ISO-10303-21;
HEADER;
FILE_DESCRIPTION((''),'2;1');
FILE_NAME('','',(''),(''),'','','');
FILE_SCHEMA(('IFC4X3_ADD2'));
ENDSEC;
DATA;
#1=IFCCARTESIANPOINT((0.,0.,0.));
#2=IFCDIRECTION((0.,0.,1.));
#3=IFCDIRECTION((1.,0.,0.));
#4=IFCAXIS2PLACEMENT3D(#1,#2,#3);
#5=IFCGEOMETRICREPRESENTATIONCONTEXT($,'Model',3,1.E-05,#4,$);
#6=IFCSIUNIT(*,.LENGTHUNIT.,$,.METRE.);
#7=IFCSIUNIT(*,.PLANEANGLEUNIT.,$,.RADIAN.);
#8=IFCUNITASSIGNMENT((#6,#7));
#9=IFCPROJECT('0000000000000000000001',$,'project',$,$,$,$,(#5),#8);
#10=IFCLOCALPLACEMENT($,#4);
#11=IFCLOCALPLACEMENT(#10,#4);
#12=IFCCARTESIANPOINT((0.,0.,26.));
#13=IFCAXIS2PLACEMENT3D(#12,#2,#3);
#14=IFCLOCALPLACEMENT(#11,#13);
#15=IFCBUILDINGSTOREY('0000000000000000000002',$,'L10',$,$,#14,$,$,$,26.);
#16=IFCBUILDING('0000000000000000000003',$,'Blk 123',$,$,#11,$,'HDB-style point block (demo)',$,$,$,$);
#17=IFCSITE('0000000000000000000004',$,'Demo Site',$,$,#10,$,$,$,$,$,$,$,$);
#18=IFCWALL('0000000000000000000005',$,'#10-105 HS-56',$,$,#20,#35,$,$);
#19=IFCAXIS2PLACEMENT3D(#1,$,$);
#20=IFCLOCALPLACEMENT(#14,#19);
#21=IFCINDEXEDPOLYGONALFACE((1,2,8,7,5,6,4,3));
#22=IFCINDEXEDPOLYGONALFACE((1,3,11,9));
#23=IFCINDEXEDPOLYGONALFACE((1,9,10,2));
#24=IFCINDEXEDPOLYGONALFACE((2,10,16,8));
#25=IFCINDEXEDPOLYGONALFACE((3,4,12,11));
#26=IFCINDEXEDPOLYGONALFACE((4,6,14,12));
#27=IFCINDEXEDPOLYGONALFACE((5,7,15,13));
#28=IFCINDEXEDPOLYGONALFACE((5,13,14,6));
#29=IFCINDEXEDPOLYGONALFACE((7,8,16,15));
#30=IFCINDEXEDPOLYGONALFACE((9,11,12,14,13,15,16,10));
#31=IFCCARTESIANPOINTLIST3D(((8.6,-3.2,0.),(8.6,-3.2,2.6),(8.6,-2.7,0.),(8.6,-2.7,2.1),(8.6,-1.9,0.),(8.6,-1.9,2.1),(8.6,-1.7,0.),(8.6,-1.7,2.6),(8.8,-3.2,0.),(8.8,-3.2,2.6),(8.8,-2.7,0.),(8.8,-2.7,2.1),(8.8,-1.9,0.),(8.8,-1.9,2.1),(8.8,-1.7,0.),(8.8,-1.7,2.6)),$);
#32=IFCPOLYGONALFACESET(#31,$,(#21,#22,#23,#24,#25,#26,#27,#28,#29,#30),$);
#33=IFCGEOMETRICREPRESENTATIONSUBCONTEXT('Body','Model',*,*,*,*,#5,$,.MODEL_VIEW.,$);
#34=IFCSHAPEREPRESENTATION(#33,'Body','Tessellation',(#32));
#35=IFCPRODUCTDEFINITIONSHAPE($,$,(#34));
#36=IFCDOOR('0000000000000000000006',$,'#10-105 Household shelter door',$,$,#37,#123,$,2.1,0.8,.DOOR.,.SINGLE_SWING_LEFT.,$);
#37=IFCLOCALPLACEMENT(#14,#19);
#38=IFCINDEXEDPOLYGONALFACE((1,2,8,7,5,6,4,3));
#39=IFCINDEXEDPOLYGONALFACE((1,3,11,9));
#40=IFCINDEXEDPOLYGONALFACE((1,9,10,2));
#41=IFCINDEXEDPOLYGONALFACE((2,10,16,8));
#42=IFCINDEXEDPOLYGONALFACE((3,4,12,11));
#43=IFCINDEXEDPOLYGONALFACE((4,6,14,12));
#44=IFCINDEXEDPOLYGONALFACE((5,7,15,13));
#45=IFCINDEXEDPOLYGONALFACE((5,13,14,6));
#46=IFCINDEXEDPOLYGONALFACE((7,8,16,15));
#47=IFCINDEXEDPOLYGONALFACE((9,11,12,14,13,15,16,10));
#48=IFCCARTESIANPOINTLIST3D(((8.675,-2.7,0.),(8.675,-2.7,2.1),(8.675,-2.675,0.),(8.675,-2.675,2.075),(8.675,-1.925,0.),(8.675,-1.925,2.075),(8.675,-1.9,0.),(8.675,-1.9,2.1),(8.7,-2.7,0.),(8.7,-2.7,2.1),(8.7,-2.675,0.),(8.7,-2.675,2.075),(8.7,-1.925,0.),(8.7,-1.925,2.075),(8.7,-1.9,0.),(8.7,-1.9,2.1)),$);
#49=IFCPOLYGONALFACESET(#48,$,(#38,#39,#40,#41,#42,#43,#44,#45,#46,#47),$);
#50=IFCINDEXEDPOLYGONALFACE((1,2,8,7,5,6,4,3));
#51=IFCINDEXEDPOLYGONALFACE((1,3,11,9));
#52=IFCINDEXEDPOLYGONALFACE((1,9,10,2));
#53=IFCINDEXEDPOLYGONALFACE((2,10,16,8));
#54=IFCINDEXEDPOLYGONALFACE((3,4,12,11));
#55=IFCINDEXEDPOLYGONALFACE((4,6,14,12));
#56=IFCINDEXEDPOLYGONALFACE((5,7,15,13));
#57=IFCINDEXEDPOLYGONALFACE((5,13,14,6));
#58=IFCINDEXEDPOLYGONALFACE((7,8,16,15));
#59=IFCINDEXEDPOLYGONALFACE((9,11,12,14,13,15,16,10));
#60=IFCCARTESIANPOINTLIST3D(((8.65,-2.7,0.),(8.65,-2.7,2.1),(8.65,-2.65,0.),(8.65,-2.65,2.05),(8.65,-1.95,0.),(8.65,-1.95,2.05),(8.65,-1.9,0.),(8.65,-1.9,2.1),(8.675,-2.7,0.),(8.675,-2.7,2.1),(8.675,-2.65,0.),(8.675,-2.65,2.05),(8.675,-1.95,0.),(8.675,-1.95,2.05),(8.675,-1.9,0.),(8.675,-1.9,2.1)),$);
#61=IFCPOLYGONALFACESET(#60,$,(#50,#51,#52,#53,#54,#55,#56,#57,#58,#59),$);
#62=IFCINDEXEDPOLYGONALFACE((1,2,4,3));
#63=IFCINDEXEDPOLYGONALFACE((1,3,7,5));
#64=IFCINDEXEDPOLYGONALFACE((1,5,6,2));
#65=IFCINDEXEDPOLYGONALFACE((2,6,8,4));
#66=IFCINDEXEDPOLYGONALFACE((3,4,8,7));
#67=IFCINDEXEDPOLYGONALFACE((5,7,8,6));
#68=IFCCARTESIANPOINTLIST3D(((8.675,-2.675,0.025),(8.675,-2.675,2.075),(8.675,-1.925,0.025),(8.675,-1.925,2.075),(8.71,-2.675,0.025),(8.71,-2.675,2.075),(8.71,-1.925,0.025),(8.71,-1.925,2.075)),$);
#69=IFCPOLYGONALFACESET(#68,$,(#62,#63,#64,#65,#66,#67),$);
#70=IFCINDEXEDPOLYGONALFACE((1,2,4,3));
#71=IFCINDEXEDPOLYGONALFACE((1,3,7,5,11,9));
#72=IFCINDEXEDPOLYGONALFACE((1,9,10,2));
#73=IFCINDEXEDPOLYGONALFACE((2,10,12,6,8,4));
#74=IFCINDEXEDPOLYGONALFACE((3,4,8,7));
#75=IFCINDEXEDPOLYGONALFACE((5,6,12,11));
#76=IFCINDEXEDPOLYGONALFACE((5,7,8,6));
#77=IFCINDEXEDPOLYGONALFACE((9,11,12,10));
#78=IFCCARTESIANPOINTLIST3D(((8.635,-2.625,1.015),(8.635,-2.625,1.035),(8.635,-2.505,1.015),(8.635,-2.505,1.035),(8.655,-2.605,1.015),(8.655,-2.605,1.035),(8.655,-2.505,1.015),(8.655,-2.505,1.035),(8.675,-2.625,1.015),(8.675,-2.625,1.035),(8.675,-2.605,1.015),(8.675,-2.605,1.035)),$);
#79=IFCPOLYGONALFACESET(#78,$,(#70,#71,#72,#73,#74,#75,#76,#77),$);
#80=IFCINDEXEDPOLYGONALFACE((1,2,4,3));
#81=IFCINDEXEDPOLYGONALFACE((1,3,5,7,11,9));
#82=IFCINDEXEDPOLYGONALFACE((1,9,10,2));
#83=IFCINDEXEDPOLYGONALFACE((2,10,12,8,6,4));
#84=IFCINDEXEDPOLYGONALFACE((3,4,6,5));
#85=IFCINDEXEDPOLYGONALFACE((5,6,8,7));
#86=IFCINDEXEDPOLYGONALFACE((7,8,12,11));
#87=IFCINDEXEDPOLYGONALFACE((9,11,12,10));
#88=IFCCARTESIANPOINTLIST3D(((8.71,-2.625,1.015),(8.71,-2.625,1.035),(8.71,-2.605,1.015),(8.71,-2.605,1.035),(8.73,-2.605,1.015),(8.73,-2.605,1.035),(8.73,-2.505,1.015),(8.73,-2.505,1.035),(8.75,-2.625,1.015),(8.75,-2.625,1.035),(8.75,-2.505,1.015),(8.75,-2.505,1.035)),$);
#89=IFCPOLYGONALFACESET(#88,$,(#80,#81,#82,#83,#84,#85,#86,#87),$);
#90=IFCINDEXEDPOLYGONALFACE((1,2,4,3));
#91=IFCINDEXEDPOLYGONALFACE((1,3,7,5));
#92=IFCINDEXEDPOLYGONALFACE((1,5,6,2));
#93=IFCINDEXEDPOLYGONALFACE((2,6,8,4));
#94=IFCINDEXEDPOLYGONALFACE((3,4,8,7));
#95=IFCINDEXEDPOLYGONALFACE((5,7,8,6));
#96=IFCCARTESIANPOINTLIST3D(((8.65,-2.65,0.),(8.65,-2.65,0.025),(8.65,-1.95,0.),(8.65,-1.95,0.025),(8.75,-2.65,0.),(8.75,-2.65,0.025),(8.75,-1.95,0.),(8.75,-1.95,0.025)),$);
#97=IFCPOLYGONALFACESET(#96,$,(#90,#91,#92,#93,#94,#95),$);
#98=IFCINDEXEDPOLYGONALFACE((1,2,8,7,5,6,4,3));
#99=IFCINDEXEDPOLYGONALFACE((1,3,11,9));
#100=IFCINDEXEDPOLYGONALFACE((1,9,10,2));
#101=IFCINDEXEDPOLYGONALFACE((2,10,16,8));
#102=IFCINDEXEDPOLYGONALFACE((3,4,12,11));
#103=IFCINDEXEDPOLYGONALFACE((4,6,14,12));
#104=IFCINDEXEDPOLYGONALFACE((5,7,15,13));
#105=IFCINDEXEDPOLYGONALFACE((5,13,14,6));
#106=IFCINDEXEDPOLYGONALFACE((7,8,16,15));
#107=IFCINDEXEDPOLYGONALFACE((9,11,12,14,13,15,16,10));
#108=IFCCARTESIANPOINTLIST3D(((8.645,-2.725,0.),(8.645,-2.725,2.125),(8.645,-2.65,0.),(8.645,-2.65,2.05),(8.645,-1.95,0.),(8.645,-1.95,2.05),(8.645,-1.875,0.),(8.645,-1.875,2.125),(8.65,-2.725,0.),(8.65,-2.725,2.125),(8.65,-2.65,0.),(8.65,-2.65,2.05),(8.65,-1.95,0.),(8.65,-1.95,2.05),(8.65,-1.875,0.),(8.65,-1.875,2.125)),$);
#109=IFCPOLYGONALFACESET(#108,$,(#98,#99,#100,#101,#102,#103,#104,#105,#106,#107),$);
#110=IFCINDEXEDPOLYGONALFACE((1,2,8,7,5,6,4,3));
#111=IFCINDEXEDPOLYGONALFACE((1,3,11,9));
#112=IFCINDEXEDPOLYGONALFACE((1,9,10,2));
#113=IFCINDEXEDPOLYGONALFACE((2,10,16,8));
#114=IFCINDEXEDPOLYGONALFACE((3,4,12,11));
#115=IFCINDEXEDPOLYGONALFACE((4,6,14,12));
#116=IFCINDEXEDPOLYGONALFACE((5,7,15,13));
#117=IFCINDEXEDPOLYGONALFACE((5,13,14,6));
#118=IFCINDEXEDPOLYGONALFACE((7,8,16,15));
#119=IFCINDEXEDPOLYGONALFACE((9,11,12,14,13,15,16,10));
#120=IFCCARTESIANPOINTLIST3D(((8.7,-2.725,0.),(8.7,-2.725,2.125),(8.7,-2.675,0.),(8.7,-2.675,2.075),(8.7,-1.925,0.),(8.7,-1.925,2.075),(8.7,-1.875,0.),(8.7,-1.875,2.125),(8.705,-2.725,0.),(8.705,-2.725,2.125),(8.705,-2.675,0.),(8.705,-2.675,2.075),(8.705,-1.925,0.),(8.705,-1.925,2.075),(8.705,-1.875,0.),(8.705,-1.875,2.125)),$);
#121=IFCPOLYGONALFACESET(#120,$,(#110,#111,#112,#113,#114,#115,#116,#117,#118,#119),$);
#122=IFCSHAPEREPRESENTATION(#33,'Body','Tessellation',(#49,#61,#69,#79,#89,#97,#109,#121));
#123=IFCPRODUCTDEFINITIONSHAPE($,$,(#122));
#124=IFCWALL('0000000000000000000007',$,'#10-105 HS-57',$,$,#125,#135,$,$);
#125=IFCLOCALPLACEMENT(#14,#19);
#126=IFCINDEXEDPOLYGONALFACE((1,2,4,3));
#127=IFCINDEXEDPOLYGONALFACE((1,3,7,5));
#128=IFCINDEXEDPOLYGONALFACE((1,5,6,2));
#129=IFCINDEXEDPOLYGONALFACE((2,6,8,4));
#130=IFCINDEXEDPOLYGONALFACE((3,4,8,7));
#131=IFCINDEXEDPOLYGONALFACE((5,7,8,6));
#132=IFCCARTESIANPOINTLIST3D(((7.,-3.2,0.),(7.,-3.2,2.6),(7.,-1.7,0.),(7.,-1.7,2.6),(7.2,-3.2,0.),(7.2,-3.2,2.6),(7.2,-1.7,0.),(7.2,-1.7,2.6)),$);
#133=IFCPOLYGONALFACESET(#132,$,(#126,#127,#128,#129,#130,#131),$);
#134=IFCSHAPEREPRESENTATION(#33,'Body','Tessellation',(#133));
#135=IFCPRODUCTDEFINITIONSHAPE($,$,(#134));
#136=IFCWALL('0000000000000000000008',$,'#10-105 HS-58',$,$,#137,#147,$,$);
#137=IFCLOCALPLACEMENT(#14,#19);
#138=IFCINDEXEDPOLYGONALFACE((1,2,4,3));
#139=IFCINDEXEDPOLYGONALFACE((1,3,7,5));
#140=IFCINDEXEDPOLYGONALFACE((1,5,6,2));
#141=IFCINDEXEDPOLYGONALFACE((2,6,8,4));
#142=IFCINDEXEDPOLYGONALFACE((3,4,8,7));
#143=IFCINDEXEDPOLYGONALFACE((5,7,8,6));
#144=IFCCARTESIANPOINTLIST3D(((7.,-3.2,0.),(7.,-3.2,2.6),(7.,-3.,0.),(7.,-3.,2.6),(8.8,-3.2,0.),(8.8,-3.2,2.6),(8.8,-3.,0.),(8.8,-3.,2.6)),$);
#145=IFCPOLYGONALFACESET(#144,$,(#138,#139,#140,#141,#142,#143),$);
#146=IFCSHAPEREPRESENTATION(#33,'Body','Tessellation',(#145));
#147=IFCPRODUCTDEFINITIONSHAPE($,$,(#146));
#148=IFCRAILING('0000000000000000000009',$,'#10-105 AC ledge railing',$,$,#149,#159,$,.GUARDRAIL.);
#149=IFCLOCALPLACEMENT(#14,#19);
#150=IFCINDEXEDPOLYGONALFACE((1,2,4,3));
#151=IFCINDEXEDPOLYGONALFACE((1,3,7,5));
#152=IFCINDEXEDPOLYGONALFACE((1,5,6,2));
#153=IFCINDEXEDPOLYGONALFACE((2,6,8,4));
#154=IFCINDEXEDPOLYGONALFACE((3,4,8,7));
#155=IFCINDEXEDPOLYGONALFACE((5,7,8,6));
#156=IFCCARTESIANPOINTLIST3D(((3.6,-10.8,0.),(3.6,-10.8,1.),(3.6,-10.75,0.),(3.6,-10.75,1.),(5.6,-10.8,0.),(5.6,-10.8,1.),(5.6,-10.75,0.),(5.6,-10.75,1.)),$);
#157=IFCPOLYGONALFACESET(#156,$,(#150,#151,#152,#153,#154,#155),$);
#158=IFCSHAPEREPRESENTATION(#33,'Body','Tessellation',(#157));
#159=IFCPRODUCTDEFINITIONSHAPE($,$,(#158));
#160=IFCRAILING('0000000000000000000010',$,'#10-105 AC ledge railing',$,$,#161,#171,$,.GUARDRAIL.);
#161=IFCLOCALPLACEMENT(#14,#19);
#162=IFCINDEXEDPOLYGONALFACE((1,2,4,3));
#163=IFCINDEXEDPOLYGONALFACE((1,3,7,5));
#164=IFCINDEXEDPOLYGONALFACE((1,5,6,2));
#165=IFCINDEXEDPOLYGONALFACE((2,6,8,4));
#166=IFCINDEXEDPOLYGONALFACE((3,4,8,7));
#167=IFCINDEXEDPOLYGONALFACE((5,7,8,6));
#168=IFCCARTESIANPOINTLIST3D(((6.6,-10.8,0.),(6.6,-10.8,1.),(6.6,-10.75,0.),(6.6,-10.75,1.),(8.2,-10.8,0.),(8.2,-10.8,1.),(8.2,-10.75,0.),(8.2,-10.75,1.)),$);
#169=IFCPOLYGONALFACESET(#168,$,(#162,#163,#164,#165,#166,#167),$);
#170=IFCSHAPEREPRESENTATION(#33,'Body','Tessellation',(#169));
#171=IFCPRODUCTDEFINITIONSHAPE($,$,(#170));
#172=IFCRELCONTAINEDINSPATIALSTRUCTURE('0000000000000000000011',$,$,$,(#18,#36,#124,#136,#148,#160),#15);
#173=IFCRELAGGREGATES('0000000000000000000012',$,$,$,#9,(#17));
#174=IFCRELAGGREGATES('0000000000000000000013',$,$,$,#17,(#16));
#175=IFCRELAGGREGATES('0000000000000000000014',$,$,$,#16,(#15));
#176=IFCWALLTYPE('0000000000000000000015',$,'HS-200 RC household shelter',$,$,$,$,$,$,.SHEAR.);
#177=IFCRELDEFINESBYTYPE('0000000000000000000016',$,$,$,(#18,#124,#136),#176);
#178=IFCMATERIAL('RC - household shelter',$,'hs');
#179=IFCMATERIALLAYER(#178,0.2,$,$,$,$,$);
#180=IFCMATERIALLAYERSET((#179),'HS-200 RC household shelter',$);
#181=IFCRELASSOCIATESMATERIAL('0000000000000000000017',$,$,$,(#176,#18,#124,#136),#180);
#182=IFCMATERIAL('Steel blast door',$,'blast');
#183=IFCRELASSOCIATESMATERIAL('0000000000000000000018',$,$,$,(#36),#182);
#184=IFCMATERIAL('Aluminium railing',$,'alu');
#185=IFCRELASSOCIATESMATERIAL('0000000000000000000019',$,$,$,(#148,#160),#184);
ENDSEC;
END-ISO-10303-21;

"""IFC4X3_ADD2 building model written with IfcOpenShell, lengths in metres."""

from ifc_helpers import new_model, si_unit, frame, origin, origin_with_axes, place, context, subcontext, project, spatial, polyline, line, indexed_curve, outline, extrude, material, layer, layer_set, layer_usage, type_object, element, fill, save


model = new_model("IFC4X3_ADD2")

# Units and contexts
model_context = context("Model", 3, precision=1e-05, world=origin_with_axes())
body_context = subcontext(model_context, "Body", "Model", "MODEL_VIEW")
ifc_project = project(units=[si_unit("LENGTHUNIT", "METRE"), si_unit("PLANEANGLEUNIT", "RADIAN")], contexts=[model_context])

# Site, building, storey
site_placement = place(None, origin_with_axes())
site = spatial("IfcSite", under=ifc_project, at=site_placement, Name="Demo Site")
building_placement = place(site_placement, origin_with_axes())
building = spatial("IfcBuilding", under=site, at=building_placement, Name="Blk 123", LongName="HDB-style point block (demo)")
storey_placement = place(building_placement, frame((0.0, 0.0, 26.0), z_axis=(0.0, 0.0, 1.0), x_axis=(1.0, 0.0, 0.0)))
storey = spatial("IfcBuildingStorey", under=building, at=storey_placement, Name="L10", Elevation=26.0)

# Wall, opening, door
ifc_material_1 = material(Name="RC - household shelter", Category="hs")
ifc_layer_1 = layer(ifc_material_1, 0.2)
ifc_layer_set_1 = layer_set([ifc_layer_1], Name="HS-200 RC household shelter")
ifc_layer_usage_1 = layer_usage(ifc_layer_set_1, "AXIS2", "POSITIVE", -0.1)
wall_type_1 = type_object("IfcWallType", Name="HS-200 RC household shelter", PredefinedType="SHEAR", material=ifc_layer_set_1)
wall_1_placement = place(storey_placement, frame((8.7, -1.7, 0.0), z_axis=(0.0, 0.0, 1.0), x_axis=(0.0, -1.0, 0.0)))
wall_1 = element("IfcWall", 1, at=wall_1_placement, inside=storey, type_object=wall_type_1, material=ifc_layer_usage_1, Name="#10-105 HS-56", context=body_context, shape_type="SweptSolid", body=[
    extrude(outline(indexed_curve([(0.0, 0.0), (0.0, 0.2), (1.5, 0.2), (1.5, 0.0), (0.0, 0.0)], self_intersect=False)), frame((0.0, -0.1, 0.0), z_axis=(0.0, 0.0, 1.0), x_axis=(1.0, 0.0, 0.0)), (0.0, 0.0, 1.0), 2.6),
])
opening_1_placement = place(wall_1_placement, frame((0.2, -0.2, 0.0), z_axis=(0.0, 0.0, 1.0), x_axis=(1.0, 0.0, 0.0)))
opening_1 = element("IfcOpeningElement", 2, at=opening_1_placement, cuts=wall_1, context=body_context, shape_type="SweptSolid", body=[
    extrude(outline(indexed_curve([(0.0, 0.0), (0.0, 0.4), (0.8, 0.4), (0.8, 0.0), (0.0, 0.0)], self_intersect=False)), origin_with_axes(), (0.0, 0.0, 1.0), 2.1),
])
ifc_material_2 = material(Name="Steel blast door", Category="blast")
door_1_placement = place(opening_1_placement, frame((0.0, 0.15, 0.0), z_axis=(0.0, 0.0, 1.0), x_axis=(1.0, 0.0, 0.0)))
door_1 = element("IfcDoor", 3, at=door_1_placement, inside=storey, material=ifc_material_2, Name="#10-105 Household shelter door", OperationType="SINGLE_SWING_LEFT", OverallHeight=2.1, OverallWidth=0.8, PredefinedType="DOOR", context=body_context, shape_type="SweptSolid", body=[
    extrude(outline(indexed_curve([(0.0, 0.0), (0.0, 2.1), (0.8, 2.1), (0.8, 0.0), (0.775, 0.0), (0.775, 2.075), (0.025, 2.075), (0.025, 0.0)], segments=[line(1, 2, 3, 4, 5, 6, 7, 8, 1)])), frame((0.0, 0.025, 0.0), z_axis=(0.0, -1.0, 0.0), x_axis=(1.0, 0.0, 0.0)), (0.0, 0.0, -1.0), 0.025),
    extrude(outline(indexed_curve([(0.0, 0.0), (0.0, 2.1), (0.8, 2.1), (0.8, 0.0), (0.75, 0.0), (0.75, 2.05), (0.05, 2.05), (0.05, 0.0)], segments=[line(1, 2, 3, 4, 5, 6, 7, 8, 1)])), frame((0.0, 0.0, 0.0), z_axis=(0.0, -1.0, 0.0), x_axis=(1.0, 0.0, 0.0)), (0.0, 0.0, -1.0), 0.025),
    extrude(outline(indexed_curve([(0.0, 0.0), (0.75, 0.0), (0.75, 0.035), (0.0, 0.035)], segments=[line(1, 2, 3, 4, 1)])), frame((0.025, 0.025, 0.025), z_axis=(0.0, 0.0, 1.0), x_axis=(1.0, 0.0, 0.0)), (0.0, 0.0, 1.0), 2.05),
    extrude(outline(indexed_curve([(0.0, 0.0), (0.0, -0.04), (-0.12, -0.04), (-0.12, -0.02), (-0.02, -0.02), (-0.02, 0.0)], segments=[line(1, 2, 3, 4, 5, 6, 1)])), frame((0.725, 0.025, 1.015), z_axis=(0.0, 0.0, 1.0), x_axis=(1.0, 0.0, 0.0)), (0.0, 0.0, 1.0), 0.02),
    extrude(outline(indexed_curve([(0.0, 0.0), (0.0, 0.04), (-0.12, 0.04), (-0.12, 0.02), (-0.02, 0.02), (-0.02, 0.0)], segments=[line(1, 2, 3, 4, 5, 6, 1)])), frame((0.725, 0.06, 1.015), z_axis=(0.0, 0.0, 1.0), x_axis=(1.0, 0.0, 0.0)), (0.0, 0.0, 1.0), 0.02),
    extrude(outline(indexed_curve([(0.0, 0.0), (0.7, 0.0), (0.7, 0.1), (0.0, 0.1)], segments=[line(1, 2, 3, 4, 1)])), frame((0.05, 0.0, 0.0), z_axis=(0.0, 0.0, 1.0), x_axis=(1.0, 0.0, 0.0)), (0.0, 0.0, 1.0), 0.025),
    extrude(outline(indexed_curve([(0.0, 0.0), (0.0, 2.125), (0.85, 2.125), (0.85, 0.0), (0.775, 0.0), (0.775, 2.05), (0.075, 2.05), (0.075, 0.0)], segments=[line(1, 2, 3, 4, 5, 6, 7, 8, 1)])), frame((-0.025, -0.005, 0.0), z_axis=(0.0, -1.0, 0.0), x_axis=(1.0, 0.0, 0.0)), (0.0, 0.0, -1.0), 0.005),
    extrude(outline(indexed_curve([(0.0, 0.0), (0.0, 2.125), (0.85, 2.125), (0.85, 0.0), (0.8, 0.0), (0.8, 2.075), (0.05, 2.075), (0.05, 0.0)], segments=[line(1, 2, 3, 4, 5, 6, 7, 8, 1)])), frame((-0.025, 0.05, 0.0), z_axis=(0.0, -1.0, 0.0), x_axis=(1.0, 0.0, 0.0)), (0.0, 0.0, -1.0), 0.005),
])
fill(opening_1, door_1)

# Walls
wall_2_placement = place(storey_placement, frame((7.1, -1.7, 0.0), z_axis=(0.0, 0.0, 1.0), x_axis=(0.0, -1.0, 0.0)))
element("IfcWall", 4, at=wall_2_placement, inside=storey, type_object=wall_type_1, material=ifc_layer_usage_1, Name="#10-105 HS-57", context=body_context, shape_type="SweptSolid", body=[
    extrude(outline(indexed_curve([(0.0, 0.0), (0.0, 0.2), (1.5, 0.2), (1.5, 0.0), (0.0, 0.0)], self_intersect=False)), frame((0.0, -0.1, 0.0), z_axis=(0.0, 0.0, 1.0), x_axis=(1.0, 0.0, 0.0)), (0.0, 0.0, 1.0), 2.6),
])
wall_3_placement = place(storey_placement, frame((7.0, -3.1, 0.0), z_axis=(0.0, 0.0, 1.0), x_axis=(1.0, 0.0, 0.0)))
element("IfcWall", 5, at=wall_3_placement, inside=storey, type_object=wall_type_1, material=ifc_layer_usage_1, Name="#10-105 HS-58", context=body_context, shape_type="SweptSolid", body=[
    extrude(outline(indexed_curve([(0.0, 0.0), (0.0, 0.2), (1.8, 0.2), (1.8, 0.0), (0.0, 0.0)], self_intersect=False)), frame((0.0, -0.1, 0.0), z_axis=(0.0, 0.0, 1.0), x_axis=(1.0, 0.0, 0.0)), (0.0, 0.0, 1.0), 2.6),
])

# Railings
ifc_material_3 = material(Name="Aluminium railing", Category="alu")
railing_1_placement = place(storey_placement, frame((4.6, -10.775, 0.0), z_axis=(0.0, 0.0, 1.0), x_axis=(1.0, 0.0, 0.0)))
element("IfcRailing", 6, at=railing_1_placement, inside=storey, material=ifc_material_3, Name="#10-105 AC ledge railing", PredefinedType="GUARDRAIL", context=body_context, shape_type="SweptSolid", body=[
    extrude(outline(polyline([(1.0, 0.025), (-1.0, 0.025), (-1.0, -0.025), (1.0, -0.025), (1.0, 0.025)])), origin(), (0.0, 0.0, 1.0), 1.0),
])
railing_2_placement = place(storey_placement, frame((7.4, -10.775, 0.0), z_axis=(0.0, 0.0, 1.0), x_axis=(1.0, 0.0, 0.0)))
element("IfcRailing", 7, at=railing_2_placement, inside=storey, material=ifc_material_3, Name="#10-105 AC ledge railing", PredefinedType="GUARDRAIL", context=body_context, shape_type="SweptSolid", body=[
    extrude(outline(polyline([(0.8, 0.025), (-0.8, 0.025), (-0.8, -0.025), (0.8, -0.025), (0.8, 0.025)])), origin(), (0.0, 0.0, 1.0), 1.0),
])

save(model, "model.ifc")
